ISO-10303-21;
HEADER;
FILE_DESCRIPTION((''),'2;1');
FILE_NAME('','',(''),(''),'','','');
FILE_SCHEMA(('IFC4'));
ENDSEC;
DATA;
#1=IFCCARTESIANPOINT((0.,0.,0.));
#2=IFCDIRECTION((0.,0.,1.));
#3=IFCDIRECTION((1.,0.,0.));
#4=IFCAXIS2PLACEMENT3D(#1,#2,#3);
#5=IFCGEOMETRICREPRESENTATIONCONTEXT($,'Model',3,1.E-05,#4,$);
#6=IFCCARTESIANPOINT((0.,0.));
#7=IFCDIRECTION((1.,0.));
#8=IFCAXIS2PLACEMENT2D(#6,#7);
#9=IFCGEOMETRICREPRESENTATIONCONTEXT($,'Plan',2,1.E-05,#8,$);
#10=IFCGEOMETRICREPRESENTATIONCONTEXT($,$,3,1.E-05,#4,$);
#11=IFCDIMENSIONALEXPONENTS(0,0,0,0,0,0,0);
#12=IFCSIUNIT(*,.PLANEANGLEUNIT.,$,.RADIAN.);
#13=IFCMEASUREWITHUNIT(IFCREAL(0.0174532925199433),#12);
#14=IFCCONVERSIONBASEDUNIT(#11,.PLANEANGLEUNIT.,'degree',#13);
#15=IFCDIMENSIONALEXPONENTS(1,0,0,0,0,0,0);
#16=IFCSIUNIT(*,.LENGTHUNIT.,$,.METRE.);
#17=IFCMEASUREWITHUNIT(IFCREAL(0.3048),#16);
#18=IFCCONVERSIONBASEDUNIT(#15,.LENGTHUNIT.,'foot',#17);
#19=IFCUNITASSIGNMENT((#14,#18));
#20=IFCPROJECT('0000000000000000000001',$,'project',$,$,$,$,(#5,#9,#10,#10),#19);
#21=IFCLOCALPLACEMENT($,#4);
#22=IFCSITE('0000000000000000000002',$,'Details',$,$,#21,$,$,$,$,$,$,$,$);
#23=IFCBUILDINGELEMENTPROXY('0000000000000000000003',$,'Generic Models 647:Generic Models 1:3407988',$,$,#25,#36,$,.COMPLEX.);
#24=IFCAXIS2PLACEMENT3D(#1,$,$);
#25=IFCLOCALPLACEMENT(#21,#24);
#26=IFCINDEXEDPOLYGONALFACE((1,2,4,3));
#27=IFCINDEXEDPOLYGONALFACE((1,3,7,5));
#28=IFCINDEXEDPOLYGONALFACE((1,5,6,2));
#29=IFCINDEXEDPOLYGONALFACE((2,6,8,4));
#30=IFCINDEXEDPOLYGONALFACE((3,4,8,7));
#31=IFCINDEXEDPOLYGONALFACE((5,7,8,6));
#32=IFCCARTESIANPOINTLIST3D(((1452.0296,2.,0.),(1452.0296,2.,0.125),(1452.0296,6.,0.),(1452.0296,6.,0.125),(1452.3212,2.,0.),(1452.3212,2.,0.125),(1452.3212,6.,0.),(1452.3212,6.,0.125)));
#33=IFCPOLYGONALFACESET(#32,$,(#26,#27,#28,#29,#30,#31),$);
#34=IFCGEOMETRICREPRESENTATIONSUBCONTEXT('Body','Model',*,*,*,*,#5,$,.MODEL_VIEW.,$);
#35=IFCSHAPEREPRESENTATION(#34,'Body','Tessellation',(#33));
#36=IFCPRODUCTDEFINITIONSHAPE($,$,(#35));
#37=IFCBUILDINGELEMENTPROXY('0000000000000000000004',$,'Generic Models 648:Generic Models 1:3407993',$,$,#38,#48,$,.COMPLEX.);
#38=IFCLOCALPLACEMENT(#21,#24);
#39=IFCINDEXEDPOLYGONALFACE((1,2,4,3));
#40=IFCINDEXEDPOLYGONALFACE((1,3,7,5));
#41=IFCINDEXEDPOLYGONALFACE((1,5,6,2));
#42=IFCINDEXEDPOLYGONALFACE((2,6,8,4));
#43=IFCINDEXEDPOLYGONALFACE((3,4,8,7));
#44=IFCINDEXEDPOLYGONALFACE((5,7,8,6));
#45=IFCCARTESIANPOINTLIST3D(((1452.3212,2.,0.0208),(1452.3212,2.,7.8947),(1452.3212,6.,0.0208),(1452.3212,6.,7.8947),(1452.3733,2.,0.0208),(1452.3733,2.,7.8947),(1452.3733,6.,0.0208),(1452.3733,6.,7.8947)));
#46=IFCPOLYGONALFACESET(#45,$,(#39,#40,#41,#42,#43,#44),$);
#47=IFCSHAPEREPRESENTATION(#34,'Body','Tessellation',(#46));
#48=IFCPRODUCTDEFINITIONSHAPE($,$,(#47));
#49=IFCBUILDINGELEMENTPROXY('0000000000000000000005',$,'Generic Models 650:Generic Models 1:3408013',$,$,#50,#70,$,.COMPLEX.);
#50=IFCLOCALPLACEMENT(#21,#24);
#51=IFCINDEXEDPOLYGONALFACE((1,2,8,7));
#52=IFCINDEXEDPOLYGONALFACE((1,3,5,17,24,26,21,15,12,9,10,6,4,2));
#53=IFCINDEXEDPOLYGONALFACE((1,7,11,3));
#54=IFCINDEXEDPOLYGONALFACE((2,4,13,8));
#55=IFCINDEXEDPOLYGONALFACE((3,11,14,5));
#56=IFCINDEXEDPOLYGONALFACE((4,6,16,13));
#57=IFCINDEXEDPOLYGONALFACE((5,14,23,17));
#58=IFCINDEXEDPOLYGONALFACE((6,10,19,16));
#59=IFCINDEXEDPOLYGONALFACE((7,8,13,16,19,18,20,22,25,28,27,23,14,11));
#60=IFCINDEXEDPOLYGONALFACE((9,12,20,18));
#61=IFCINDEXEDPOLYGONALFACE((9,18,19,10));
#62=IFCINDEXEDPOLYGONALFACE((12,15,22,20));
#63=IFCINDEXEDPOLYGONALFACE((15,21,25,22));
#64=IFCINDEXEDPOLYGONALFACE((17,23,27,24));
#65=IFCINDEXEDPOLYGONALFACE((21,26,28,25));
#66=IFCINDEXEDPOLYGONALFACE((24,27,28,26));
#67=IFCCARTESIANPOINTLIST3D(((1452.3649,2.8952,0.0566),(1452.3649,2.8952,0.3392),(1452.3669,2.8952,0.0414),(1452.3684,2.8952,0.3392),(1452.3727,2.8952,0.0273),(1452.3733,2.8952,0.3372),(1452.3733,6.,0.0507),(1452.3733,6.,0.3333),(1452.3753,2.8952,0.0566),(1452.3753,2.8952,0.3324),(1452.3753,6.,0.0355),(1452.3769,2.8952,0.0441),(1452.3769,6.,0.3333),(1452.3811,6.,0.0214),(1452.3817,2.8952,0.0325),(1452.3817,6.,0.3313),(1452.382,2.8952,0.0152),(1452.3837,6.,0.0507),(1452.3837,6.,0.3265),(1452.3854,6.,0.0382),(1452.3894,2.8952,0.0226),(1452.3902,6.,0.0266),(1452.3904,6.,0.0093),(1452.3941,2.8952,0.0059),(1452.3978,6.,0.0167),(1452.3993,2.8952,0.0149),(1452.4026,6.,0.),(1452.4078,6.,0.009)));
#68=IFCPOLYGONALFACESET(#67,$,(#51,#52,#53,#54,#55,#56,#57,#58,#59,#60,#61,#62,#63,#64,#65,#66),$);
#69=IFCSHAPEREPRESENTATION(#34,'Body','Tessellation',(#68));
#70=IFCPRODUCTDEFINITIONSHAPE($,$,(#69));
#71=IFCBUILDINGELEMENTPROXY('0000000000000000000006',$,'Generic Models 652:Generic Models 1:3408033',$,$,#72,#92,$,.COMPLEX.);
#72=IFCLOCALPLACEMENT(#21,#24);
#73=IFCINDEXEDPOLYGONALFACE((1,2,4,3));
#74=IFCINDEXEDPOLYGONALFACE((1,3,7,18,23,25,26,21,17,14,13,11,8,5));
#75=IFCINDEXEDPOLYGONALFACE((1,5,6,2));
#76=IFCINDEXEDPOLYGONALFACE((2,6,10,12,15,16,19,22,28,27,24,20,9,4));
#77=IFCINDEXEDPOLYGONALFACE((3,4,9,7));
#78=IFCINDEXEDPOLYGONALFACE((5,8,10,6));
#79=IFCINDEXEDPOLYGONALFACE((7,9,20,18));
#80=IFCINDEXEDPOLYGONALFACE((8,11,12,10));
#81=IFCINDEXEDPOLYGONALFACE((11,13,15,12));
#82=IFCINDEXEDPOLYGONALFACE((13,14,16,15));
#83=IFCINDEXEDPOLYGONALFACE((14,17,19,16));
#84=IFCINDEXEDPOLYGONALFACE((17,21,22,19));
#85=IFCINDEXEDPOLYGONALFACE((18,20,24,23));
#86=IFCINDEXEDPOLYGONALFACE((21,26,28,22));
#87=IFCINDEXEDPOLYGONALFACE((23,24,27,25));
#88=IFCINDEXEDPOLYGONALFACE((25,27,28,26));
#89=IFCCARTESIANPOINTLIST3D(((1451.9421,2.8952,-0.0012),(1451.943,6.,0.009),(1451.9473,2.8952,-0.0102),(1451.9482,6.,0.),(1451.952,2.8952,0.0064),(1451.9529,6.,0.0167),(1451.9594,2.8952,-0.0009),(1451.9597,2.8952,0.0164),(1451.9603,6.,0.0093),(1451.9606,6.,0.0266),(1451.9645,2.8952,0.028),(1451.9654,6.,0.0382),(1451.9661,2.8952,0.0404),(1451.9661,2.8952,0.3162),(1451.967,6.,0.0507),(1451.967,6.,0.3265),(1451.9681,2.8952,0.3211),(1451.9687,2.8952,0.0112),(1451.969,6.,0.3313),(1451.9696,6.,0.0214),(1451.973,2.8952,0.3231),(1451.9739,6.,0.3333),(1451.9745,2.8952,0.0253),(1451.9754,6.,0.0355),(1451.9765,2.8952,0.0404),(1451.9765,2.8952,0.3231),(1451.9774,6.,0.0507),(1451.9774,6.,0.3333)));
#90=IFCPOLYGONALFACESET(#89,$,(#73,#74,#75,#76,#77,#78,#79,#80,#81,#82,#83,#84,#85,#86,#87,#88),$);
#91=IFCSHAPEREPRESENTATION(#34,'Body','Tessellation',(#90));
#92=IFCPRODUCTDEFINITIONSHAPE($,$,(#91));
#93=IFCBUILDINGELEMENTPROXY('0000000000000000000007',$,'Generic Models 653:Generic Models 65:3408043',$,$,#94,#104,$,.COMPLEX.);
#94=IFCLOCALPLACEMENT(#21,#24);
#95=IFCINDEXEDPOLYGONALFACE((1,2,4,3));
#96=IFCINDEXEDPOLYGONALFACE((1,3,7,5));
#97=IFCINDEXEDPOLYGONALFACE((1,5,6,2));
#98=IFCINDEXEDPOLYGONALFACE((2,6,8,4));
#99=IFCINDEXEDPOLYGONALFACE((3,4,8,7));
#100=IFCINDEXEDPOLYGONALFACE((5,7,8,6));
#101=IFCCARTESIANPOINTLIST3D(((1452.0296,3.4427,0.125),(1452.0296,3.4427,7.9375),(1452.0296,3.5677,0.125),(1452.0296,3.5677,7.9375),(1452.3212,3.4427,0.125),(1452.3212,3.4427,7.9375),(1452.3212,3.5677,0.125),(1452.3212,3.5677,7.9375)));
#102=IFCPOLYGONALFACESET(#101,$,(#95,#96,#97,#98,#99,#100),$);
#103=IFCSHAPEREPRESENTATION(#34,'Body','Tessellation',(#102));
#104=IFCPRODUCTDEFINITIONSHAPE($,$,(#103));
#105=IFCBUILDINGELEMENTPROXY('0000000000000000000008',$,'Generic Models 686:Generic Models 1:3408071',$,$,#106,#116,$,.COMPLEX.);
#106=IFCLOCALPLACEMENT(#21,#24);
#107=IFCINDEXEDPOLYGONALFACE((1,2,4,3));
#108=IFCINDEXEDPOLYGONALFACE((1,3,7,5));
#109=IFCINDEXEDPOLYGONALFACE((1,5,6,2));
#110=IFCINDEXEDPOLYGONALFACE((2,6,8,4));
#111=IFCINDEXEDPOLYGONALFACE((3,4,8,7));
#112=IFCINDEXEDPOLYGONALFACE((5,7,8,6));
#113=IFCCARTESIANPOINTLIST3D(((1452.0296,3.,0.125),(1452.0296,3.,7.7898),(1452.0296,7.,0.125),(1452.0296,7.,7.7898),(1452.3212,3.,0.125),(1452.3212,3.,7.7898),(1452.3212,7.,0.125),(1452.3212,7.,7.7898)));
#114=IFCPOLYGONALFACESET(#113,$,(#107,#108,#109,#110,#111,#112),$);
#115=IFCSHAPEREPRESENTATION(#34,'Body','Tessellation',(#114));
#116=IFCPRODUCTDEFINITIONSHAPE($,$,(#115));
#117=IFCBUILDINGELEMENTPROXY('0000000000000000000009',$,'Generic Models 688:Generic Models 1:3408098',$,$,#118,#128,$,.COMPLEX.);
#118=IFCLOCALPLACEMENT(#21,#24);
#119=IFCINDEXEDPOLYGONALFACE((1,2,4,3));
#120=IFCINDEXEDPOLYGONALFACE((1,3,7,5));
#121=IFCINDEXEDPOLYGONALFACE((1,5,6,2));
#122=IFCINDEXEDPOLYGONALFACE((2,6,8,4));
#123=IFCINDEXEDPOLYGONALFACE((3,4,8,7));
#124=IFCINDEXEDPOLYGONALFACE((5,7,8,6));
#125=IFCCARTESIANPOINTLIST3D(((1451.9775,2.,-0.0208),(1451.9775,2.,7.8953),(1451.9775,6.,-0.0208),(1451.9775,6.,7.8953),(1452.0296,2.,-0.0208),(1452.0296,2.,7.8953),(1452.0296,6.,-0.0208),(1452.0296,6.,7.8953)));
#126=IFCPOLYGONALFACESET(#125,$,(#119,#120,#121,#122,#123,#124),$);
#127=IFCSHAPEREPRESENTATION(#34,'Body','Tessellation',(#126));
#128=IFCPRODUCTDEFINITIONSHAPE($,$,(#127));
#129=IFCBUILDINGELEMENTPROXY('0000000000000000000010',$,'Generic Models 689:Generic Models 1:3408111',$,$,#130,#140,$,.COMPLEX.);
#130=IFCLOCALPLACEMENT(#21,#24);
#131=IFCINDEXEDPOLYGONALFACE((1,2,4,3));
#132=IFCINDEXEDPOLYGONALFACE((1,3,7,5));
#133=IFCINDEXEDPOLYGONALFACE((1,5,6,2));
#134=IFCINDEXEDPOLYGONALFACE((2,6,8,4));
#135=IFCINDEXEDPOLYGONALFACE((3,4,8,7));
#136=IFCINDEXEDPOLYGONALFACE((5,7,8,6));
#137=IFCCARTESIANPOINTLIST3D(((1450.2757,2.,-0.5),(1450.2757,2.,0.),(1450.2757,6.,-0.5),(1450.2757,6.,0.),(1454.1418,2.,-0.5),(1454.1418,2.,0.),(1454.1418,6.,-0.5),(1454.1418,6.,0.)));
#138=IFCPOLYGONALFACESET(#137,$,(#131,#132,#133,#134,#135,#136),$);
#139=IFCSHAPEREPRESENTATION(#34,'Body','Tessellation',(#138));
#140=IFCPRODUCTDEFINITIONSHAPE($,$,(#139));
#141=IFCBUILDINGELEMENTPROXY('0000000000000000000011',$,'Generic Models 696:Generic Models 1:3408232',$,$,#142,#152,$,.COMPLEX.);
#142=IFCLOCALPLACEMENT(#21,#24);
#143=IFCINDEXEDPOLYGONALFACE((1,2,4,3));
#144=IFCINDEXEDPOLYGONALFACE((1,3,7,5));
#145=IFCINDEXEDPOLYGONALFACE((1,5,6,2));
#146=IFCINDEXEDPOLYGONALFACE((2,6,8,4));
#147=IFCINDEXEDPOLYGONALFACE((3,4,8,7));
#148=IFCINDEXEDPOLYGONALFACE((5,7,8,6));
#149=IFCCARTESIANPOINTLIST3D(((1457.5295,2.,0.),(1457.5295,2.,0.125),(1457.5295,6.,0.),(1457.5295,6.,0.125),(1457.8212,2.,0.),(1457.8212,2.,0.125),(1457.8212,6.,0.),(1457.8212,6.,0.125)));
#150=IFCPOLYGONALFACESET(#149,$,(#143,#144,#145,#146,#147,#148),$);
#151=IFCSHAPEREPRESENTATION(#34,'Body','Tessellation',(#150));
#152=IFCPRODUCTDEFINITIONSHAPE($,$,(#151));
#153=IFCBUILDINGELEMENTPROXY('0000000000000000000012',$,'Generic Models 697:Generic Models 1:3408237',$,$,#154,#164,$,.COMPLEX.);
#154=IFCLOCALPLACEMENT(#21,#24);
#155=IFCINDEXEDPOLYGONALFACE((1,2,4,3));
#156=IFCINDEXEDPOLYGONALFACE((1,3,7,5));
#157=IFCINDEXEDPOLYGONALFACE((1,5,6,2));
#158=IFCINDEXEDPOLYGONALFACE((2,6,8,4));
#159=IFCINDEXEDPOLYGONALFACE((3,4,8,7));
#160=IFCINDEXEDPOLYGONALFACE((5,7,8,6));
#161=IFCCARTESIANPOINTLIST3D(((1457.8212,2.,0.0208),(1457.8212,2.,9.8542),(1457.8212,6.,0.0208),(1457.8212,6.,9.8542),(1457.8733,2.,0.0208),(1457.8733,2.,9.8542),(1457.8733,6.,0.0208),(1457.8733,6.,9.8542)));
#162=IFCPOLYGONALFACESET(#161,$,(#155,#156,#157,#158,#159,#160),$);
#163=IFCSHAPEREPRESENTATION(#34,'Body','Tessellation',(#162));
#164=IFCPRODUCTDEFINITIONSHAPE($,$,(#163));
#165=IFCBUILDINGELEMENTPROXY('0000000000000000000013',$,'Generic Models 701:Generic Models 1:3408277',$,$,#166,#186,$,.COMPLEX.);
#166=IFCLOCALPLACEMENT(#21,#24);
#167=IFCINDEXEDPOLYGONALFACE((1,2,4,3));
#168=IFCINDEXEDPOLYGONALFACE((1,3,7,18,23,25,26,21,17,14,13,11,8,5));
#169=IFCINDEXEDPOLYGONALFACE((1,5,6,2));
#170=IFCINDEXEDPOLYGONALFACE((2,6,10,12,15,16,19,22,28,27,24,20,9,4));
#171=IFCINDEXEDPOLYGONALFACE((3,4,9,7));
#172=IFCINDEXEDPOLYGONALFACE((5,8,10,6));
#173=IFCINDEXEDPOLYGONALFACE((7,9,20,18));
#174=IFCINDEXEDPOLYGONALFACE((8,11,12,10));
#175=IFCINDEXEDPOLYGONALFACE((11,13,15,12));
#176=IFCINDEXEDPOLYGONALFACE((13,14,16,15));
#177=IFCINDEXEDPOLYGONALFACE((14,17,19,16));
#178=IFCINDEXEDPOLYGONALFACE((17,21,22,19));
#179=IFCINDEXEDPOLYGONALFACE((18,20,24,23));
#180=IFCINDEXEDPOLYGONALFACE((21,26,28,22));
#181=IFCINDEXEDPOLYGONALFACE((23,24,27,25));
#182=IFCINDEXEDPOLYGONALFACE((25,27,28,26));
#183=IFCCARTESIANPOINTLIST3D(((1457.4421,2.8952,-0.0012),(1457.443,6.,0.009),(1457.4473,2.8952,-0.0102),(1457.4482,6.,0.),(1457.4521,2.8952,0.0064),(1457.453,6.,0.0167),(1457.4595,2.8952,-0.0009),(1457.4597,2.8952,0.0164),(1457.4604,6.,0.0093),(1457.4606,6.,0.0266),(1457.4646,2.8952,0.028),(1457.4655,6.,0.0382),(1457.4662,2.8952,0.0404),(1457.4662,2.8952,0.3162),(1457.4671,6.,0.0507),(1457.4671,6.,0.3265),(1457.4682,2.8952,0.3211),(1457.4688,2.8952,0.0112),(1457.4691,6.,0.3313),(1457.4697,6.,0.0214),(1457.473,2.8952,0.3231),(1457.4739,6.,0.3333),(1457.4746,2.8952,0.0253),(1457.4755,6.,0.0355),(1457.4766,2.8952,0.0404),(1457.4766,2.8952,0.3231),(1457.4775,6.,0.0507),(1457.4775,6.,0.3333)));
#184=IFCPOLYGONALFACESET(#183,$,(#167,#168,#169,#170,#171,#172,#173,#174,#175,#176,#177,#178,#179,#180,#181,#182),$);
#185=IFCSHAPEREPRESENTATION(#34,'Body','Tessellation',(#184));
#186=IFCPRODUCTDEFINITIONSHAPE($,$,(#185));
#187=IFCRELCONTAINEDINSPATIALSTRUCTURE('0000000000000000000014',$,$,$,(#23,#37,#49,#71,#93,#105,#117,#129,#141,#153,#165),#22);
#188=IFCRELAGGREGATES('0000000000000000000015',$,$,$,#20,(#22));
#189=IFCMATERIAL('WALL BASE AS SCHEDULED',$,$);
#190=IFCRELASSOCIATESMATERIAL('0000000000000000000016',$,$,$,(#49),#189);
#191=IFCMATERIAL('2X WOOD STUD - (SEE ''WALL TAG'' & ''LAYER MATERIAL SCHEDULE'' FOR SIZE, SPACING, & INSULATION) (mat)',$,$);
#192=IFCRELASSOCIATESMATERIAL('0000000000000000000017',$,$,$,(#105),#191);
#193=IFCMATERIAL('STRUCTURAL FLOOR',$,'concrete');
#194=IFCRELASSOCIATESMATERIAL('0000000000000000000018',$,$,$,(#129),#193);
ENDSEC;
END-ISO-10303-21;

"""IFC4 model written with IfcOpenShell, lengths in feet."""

from ifc_helpers import new_model, entity, si_unit, converted_unit, frame, origin_with_axes, origin_2d_with_axis, place, context, subcontext, project, spatial, polyline, outline, extrude, material, element, save


model = new_model("IFC4")

# Units and contexts
model_context = context("Model", 3, precision=1e-05, world=origin_with_axes())
plan_context = context("Plan", 2, precision=1e-05, world=origin_2d_with_axis())
context_of_model = context(None, 3, precision=1e-05, world=origin_with_axes())
body_context = subcontext(model_context, "Body", "Model", "MODEL_VIEW")
ifc_project = project(units=[converted_unit("PLANEANGLEUNIT", "degree", entity("IfcReal", 0.0174532925199433), si_unit("PLANEANGLEUNIT", "RADIAN"), dimensions=[0, 0, 0, 0, 0, 0, 0]), converted_unit("LENGTHUNIT", "foot", entity("IfcReal", 0.3048), si_unit("LENGTHUNIT", "METRE"), dimensions=[1, 0, 0, 0, 0, 0, 0])], contexts=[model_context, plan_context, context_of_model, context_of_model])

# Site
site_placement = place(None, origin_with_axes())
site = spatial("IfcSite", under=ifc_project, at=site_placement, Name="Details")

# Building element proxies
proxy_1_placement = place(site_placement, frame((1452.0296, 6.0, 0.0), z_axis=(0.0, -1.0, 0.0), x_axis=(0.0, 0.0, 1.0)))
element("IfcBuildingElementProxy", 1, at=proxy_1_placement, inside=site, Name="Generic Models 647:Generic Models 1:3407988", PredefinedType="COMPLEX", context=body_context, shape_type="SweptSolid", body=[
    extrude(outline(polyline([(-0.0625, -0.1458), (0.0625, -0.1458), (0.0625, 0.1458), (-0.0625, 0.1458), (-0.0625, -0.1458)])), frame((0.0625, -0.1458, 0.0), z_axis=(0.0, 0.0, -1.0), x_axis=(1.0, 0.0, 0.0)), (0.0, 0.0, -1.0), 4.0),
])
proxy_2_placement = place(site_placement, frame((1452.3212, 6.0, 0.0208), z_axis=(0.0, -1.0, 0.0), x_axis=(0.0, 0.0, 1.0)))
element("IfcBuildingElementProxy", 2, at=proxy_2_placement, inside=site, Name="Generic Models 648:Generic Models 1:3407993", PredefinedType="COMPLEX", context=body_context, shape_type="SweptSolid", body=[
    extrude(outline(polyline([(-3.9369, -0.026), (3.9369, -0.026), (3.9369, 0.026), (-3.9369, 0.026), (-3.9369, -0.026)])), frame((3.9369, -0.026, 0.0), z_axis=(0.0, 0.0, -1.0), x_axis=(1.0, 0.0, 0.0)), (0.0, 0.0, -1.0), 4.0),
])
ifc_material_1 = material(Name="WALL BASE AS SCHEDULED")
proxy_3_placement = place(site_placement, frame((1452.3733, 6.0, 0.0), z_axis=(0.0, -1.0, 0.0), x_axis=(0.0, 0.0, 1.0)))
element("IfcBuildingElementProxy", 3, at=proxy_3_placement, inside=site, material=ifc_material_1, Name="Generic Models 650:Generic Models 1:3408013", PredefinedType="COMPLEX", context=body_context, shape_type="SweptSolid", body=[
    extrude(outline(polyline([(0.2206, 0.0), (0.2204, 0.0036), (0.2182, 0.0083), (0.2132, 0.01), (-0.0621, -0.0058), (-0.0747, -0.0049), (-0.0865, -0.0007), (-0.0969, 0.0063), (-0.1051, 0.0158), (-0.1138, 0.0101), (-0.1038, -0.0014), (-0.0912, -0.01), (-0.0768, -0.0151), (-0.0615, -0.0162), (0.2206, 0.0)])), frame((0.113, -0.0126, 0.0), z_axis=(0.0, 0.0, -1.0), x_axis=(0.998358, 0.057286, 0.0)), (0.002054, -0.002598, -0.999995), 3.1048),
])
proxy_4_placement = place(site_placement, frame((1451.943, 6.0, 0.0), z_axis=(0.0, -1.0, 0.0), x_axis=(0.0, 0.0, 1.0)))
element("IfcBuildingElementProxy", 4, at=proxy_4_placement, inside=site, Name="Generic Models 652:Generic Models 1:3408033", PredefinedType="COMPLEX", context=body_context, shape_type="SweptSolid", body=[
    extrude(outline(polyline([(-0.0624, 0.0022), (0.2134, 0.0022), (0.2183, 0.0042), (0.2203, 0.0091), (0.2203, 0.0126), (-0.0624, 0.0126), (-0.0775, 0.0106), (-0.0916, 0.0048), (-0.1037, -0.0045), (-0.113, -0.0166), (-0.104, -0.0218), (-0.0964, -0.0119), (-0.0864, -0.0042), (-0.0748, 0.0006), (-0.0624, 0.0022)])), frame((0.113, -0.0218, 0.0), z_axis=(0.0, 0.0, -1.0), x_axis=(1.0, 0.0, 0.0)), (-0.003299, -0.000291, -0.999995), 3.1048),
])
proxy_5_placement = place(site_placement, frame((1452.0296, 3.4427, 0.125), z_axis=(0.0, 0.0, 1.0), x_axis=(1.0, 0.0, 0.0)))
element("IfcBuildingElementProxy", 5, at=proxy_5_placement, inside=site, Name="Generic Models 653:Generic Models 65:3408043", PredefinedType="COMPLEX", context=body_context, shape_type="SweptSolid", body=[
    extrude(outline(polyline([(-0.1458, -0.0625), (0.1458, -0.0625), (0.1458, 0.0625), (-0.1458, 0.0625), (-0.1458, -0.0625)])), frame((0.1458, 0.0625, 0.0), z_axis=(0.0, 0.0, -1.0), x_axis=(-1.0, 0.0, 0.0)), (0.0, 0.0, -1.0), 7.8125),
])
ifc_material_2 = material(Name="2X WOOD STUD - (SEE 'WALL TAG' & 'LAYER MATERIAL SCHEDULE' FOR SIZE, SPACING, & INSULATION) (mat)")
proxy_6_placement = place(site_placement, frame((1452.0296, 7.0, 0.125), z_axis=(0.0, -1.0, 0.0), x_axis=(0.0, 0.0, 1.0)))
element("IfcBuildingElementProxy", 6, at=proxy_6_placement, inside=site, material=ifc_material_2, Name="Generic Models 686:Generic Models 1:3408071", PredefinedType="COMPLEX", context=body_context, shape_type="SweptSolid", body=[
    extrude(outline(polyline([(-3.8324, -0.1458), (3.8324, -0.1458), (3.8324, 0.1458), (-3.8324, 0.1458), (-3.8324, -0.1458)])), frame((3.8324, -0.1458, 0.0), z_axis=(0.0, 0.0, -1.0), x_axis=(-1.0, 0.0, 0.0)), (0.0, 0.0, -1.0), 4.0),
])
proxy_7_placement = place(site_placement, frame((1451.9775, 6.0, -0.0208), z_axis=(0.0, -1.0, 0.0), x_axis=(0.0, 0.0, 1.0)))
element("IfcBuildingElementProxy", 7, at=proxy_7_placement, inside=site, Name="Generic Models 688:Generic Models 1:3408098", PredefinedType="COMPLEX", context=body_context, shape_type="SweptSolid", body=[
    extrude(outline(polyline([(-3.9581, -0.026), (3.9581, -0.026), (3.9581, 0.026), (-3.9581, 0.026), (-3.9581, -0.026)])), frame((3.9581, -0.026, 0.0), z_axis=(0.0, 0.0, -1.0), x_axis=(1.0, 0.0, 0.0)), (0.0, 0.0, -1.0), 4.0),
])
ifc_material_3 = material(Name="STRUCTURAL FLOOR", Category="concrete")
proxy_8_placement = place(site_placement, frame((1450.2757, 6.0, -0.5), z_axis=(0.0, -1.0, 0.0), x_axis=(0.0, 0.0, 1.0)))
element("IfcBuildingElementProxy", 8, at=proxy_8_placement, inside=site, material=ifc_material_3, Name="Generic Models 689:Generic Models 1:3408111", PredefinedType="COMPLEX", context=body_context, shape_type="SweptSolid", body=[
    extrude(outline(polyline([(-0.25, -1.9331), (0.25, -1.9331), (0.25, 1.9331), (-0.25, 1.9331), (-0.25, -1.9331)])), frame((0.25, -1.9331, 0.0), z_axis=(0.0, 0.0, -1.0), x_axis=(1.0, 0.0, 0.0)), (0.0, 0.0, -1.0), 4.0),
])
proxy_9_placement = place(site_placement, frame((1457.5295, 6.0, 0.0), z_axis=(0.0, -1.0, 0.0), x_axis=(0.0, 0.0, 1.0)))
element("IfcBuildingElementProxy", 9, at=proxy_9_placement, inside=site, Name="Generic Models 696:Generic Models 1:3408232", PredefinedType="COMPLEX", context=body_context, shape_type="SweptSolid", body=[
    extrude(outline(polyline([(-0.0625, -0.1458), (0.0625, -0.1458), (0.0625, 0.1458), (-0.0625, 0.1458), (-0.0625, -0.1458)])), frame((0.0625, -0.1458, 0.0), z_axis=(0.0, 0.0, -1.0), x_axis=(1.0, 0.0, 0.0)), (0.0, 0.0, -1.0), 4.0),
])
proxy_10_placement = place(site_placement, frame((1457.8212, 6.0, 0.0208), z_axis=(0.0, -1.0, 0.0), x_axis=(0.0, 0.0, 1.0)))
element("IfcBuildingElementProxy", 10, at=proxy_10_placement, inside=site, Name="Generic Models 697:Generic Models 1:3408237", PredefinedType="COMPLEX", context=body_context, shape_type="SweptSolid", body=[
    extrude(outline(polyline([(-4.9167, -0.026), (4.9167, -0.026), (4.9167, 0.026), (-4.9167, 0.026), (-4.9167, -0.026)])), frame((4.9167, -0.026, 0.0), z_axis=(0.0, 0.0, -1.0), x_axis=(1.0, 0.0, 0.0)), (0.0, 0.0, -1.0), 4.0),
])
proxy_11_placement = place(site_placement, frame((1457.443, 6.0, 0.0), z_axis=(0.0, -1.0, 0.0), x_axis=(0.0, 0.0, 1.0)))
element("IfcBuildingElementProxy", 11, at=proxy_11_placement, inside=site, Name="Generic Models 701:Generic Models 1:3408277", PredefinedType="COMPLEX", context=body_context, shape_type="SweptSolid", body=[
    extrude(outline(polyline([(-0.0624, 0.0022), (0.2134, 0.0022), (0.2183, 0.0042), (0.2203, 0.0091), (0.2203, 0.0126), (-0.0624, 0.0126), (-0.0775, 0.0106), (-0.0916, 0.0048), (-0.1037, -0.0045), (-0.113, -0.0166), (-0.104, -0.0218), (-0.0964, -0.0119), (-0.0864, -0.0042), (-0.0748, 0.0006), (-0.0624, 0.0022)])), frame((0.113, -0.0218, 0.0), z_axis=(0.0, 0.0, -1.0), x_axis=(1.0, 0.0, 0.0)), (-0.003299, -0.000291, -0.999995), 3.1048),
])

save(model, "model.ifc")
